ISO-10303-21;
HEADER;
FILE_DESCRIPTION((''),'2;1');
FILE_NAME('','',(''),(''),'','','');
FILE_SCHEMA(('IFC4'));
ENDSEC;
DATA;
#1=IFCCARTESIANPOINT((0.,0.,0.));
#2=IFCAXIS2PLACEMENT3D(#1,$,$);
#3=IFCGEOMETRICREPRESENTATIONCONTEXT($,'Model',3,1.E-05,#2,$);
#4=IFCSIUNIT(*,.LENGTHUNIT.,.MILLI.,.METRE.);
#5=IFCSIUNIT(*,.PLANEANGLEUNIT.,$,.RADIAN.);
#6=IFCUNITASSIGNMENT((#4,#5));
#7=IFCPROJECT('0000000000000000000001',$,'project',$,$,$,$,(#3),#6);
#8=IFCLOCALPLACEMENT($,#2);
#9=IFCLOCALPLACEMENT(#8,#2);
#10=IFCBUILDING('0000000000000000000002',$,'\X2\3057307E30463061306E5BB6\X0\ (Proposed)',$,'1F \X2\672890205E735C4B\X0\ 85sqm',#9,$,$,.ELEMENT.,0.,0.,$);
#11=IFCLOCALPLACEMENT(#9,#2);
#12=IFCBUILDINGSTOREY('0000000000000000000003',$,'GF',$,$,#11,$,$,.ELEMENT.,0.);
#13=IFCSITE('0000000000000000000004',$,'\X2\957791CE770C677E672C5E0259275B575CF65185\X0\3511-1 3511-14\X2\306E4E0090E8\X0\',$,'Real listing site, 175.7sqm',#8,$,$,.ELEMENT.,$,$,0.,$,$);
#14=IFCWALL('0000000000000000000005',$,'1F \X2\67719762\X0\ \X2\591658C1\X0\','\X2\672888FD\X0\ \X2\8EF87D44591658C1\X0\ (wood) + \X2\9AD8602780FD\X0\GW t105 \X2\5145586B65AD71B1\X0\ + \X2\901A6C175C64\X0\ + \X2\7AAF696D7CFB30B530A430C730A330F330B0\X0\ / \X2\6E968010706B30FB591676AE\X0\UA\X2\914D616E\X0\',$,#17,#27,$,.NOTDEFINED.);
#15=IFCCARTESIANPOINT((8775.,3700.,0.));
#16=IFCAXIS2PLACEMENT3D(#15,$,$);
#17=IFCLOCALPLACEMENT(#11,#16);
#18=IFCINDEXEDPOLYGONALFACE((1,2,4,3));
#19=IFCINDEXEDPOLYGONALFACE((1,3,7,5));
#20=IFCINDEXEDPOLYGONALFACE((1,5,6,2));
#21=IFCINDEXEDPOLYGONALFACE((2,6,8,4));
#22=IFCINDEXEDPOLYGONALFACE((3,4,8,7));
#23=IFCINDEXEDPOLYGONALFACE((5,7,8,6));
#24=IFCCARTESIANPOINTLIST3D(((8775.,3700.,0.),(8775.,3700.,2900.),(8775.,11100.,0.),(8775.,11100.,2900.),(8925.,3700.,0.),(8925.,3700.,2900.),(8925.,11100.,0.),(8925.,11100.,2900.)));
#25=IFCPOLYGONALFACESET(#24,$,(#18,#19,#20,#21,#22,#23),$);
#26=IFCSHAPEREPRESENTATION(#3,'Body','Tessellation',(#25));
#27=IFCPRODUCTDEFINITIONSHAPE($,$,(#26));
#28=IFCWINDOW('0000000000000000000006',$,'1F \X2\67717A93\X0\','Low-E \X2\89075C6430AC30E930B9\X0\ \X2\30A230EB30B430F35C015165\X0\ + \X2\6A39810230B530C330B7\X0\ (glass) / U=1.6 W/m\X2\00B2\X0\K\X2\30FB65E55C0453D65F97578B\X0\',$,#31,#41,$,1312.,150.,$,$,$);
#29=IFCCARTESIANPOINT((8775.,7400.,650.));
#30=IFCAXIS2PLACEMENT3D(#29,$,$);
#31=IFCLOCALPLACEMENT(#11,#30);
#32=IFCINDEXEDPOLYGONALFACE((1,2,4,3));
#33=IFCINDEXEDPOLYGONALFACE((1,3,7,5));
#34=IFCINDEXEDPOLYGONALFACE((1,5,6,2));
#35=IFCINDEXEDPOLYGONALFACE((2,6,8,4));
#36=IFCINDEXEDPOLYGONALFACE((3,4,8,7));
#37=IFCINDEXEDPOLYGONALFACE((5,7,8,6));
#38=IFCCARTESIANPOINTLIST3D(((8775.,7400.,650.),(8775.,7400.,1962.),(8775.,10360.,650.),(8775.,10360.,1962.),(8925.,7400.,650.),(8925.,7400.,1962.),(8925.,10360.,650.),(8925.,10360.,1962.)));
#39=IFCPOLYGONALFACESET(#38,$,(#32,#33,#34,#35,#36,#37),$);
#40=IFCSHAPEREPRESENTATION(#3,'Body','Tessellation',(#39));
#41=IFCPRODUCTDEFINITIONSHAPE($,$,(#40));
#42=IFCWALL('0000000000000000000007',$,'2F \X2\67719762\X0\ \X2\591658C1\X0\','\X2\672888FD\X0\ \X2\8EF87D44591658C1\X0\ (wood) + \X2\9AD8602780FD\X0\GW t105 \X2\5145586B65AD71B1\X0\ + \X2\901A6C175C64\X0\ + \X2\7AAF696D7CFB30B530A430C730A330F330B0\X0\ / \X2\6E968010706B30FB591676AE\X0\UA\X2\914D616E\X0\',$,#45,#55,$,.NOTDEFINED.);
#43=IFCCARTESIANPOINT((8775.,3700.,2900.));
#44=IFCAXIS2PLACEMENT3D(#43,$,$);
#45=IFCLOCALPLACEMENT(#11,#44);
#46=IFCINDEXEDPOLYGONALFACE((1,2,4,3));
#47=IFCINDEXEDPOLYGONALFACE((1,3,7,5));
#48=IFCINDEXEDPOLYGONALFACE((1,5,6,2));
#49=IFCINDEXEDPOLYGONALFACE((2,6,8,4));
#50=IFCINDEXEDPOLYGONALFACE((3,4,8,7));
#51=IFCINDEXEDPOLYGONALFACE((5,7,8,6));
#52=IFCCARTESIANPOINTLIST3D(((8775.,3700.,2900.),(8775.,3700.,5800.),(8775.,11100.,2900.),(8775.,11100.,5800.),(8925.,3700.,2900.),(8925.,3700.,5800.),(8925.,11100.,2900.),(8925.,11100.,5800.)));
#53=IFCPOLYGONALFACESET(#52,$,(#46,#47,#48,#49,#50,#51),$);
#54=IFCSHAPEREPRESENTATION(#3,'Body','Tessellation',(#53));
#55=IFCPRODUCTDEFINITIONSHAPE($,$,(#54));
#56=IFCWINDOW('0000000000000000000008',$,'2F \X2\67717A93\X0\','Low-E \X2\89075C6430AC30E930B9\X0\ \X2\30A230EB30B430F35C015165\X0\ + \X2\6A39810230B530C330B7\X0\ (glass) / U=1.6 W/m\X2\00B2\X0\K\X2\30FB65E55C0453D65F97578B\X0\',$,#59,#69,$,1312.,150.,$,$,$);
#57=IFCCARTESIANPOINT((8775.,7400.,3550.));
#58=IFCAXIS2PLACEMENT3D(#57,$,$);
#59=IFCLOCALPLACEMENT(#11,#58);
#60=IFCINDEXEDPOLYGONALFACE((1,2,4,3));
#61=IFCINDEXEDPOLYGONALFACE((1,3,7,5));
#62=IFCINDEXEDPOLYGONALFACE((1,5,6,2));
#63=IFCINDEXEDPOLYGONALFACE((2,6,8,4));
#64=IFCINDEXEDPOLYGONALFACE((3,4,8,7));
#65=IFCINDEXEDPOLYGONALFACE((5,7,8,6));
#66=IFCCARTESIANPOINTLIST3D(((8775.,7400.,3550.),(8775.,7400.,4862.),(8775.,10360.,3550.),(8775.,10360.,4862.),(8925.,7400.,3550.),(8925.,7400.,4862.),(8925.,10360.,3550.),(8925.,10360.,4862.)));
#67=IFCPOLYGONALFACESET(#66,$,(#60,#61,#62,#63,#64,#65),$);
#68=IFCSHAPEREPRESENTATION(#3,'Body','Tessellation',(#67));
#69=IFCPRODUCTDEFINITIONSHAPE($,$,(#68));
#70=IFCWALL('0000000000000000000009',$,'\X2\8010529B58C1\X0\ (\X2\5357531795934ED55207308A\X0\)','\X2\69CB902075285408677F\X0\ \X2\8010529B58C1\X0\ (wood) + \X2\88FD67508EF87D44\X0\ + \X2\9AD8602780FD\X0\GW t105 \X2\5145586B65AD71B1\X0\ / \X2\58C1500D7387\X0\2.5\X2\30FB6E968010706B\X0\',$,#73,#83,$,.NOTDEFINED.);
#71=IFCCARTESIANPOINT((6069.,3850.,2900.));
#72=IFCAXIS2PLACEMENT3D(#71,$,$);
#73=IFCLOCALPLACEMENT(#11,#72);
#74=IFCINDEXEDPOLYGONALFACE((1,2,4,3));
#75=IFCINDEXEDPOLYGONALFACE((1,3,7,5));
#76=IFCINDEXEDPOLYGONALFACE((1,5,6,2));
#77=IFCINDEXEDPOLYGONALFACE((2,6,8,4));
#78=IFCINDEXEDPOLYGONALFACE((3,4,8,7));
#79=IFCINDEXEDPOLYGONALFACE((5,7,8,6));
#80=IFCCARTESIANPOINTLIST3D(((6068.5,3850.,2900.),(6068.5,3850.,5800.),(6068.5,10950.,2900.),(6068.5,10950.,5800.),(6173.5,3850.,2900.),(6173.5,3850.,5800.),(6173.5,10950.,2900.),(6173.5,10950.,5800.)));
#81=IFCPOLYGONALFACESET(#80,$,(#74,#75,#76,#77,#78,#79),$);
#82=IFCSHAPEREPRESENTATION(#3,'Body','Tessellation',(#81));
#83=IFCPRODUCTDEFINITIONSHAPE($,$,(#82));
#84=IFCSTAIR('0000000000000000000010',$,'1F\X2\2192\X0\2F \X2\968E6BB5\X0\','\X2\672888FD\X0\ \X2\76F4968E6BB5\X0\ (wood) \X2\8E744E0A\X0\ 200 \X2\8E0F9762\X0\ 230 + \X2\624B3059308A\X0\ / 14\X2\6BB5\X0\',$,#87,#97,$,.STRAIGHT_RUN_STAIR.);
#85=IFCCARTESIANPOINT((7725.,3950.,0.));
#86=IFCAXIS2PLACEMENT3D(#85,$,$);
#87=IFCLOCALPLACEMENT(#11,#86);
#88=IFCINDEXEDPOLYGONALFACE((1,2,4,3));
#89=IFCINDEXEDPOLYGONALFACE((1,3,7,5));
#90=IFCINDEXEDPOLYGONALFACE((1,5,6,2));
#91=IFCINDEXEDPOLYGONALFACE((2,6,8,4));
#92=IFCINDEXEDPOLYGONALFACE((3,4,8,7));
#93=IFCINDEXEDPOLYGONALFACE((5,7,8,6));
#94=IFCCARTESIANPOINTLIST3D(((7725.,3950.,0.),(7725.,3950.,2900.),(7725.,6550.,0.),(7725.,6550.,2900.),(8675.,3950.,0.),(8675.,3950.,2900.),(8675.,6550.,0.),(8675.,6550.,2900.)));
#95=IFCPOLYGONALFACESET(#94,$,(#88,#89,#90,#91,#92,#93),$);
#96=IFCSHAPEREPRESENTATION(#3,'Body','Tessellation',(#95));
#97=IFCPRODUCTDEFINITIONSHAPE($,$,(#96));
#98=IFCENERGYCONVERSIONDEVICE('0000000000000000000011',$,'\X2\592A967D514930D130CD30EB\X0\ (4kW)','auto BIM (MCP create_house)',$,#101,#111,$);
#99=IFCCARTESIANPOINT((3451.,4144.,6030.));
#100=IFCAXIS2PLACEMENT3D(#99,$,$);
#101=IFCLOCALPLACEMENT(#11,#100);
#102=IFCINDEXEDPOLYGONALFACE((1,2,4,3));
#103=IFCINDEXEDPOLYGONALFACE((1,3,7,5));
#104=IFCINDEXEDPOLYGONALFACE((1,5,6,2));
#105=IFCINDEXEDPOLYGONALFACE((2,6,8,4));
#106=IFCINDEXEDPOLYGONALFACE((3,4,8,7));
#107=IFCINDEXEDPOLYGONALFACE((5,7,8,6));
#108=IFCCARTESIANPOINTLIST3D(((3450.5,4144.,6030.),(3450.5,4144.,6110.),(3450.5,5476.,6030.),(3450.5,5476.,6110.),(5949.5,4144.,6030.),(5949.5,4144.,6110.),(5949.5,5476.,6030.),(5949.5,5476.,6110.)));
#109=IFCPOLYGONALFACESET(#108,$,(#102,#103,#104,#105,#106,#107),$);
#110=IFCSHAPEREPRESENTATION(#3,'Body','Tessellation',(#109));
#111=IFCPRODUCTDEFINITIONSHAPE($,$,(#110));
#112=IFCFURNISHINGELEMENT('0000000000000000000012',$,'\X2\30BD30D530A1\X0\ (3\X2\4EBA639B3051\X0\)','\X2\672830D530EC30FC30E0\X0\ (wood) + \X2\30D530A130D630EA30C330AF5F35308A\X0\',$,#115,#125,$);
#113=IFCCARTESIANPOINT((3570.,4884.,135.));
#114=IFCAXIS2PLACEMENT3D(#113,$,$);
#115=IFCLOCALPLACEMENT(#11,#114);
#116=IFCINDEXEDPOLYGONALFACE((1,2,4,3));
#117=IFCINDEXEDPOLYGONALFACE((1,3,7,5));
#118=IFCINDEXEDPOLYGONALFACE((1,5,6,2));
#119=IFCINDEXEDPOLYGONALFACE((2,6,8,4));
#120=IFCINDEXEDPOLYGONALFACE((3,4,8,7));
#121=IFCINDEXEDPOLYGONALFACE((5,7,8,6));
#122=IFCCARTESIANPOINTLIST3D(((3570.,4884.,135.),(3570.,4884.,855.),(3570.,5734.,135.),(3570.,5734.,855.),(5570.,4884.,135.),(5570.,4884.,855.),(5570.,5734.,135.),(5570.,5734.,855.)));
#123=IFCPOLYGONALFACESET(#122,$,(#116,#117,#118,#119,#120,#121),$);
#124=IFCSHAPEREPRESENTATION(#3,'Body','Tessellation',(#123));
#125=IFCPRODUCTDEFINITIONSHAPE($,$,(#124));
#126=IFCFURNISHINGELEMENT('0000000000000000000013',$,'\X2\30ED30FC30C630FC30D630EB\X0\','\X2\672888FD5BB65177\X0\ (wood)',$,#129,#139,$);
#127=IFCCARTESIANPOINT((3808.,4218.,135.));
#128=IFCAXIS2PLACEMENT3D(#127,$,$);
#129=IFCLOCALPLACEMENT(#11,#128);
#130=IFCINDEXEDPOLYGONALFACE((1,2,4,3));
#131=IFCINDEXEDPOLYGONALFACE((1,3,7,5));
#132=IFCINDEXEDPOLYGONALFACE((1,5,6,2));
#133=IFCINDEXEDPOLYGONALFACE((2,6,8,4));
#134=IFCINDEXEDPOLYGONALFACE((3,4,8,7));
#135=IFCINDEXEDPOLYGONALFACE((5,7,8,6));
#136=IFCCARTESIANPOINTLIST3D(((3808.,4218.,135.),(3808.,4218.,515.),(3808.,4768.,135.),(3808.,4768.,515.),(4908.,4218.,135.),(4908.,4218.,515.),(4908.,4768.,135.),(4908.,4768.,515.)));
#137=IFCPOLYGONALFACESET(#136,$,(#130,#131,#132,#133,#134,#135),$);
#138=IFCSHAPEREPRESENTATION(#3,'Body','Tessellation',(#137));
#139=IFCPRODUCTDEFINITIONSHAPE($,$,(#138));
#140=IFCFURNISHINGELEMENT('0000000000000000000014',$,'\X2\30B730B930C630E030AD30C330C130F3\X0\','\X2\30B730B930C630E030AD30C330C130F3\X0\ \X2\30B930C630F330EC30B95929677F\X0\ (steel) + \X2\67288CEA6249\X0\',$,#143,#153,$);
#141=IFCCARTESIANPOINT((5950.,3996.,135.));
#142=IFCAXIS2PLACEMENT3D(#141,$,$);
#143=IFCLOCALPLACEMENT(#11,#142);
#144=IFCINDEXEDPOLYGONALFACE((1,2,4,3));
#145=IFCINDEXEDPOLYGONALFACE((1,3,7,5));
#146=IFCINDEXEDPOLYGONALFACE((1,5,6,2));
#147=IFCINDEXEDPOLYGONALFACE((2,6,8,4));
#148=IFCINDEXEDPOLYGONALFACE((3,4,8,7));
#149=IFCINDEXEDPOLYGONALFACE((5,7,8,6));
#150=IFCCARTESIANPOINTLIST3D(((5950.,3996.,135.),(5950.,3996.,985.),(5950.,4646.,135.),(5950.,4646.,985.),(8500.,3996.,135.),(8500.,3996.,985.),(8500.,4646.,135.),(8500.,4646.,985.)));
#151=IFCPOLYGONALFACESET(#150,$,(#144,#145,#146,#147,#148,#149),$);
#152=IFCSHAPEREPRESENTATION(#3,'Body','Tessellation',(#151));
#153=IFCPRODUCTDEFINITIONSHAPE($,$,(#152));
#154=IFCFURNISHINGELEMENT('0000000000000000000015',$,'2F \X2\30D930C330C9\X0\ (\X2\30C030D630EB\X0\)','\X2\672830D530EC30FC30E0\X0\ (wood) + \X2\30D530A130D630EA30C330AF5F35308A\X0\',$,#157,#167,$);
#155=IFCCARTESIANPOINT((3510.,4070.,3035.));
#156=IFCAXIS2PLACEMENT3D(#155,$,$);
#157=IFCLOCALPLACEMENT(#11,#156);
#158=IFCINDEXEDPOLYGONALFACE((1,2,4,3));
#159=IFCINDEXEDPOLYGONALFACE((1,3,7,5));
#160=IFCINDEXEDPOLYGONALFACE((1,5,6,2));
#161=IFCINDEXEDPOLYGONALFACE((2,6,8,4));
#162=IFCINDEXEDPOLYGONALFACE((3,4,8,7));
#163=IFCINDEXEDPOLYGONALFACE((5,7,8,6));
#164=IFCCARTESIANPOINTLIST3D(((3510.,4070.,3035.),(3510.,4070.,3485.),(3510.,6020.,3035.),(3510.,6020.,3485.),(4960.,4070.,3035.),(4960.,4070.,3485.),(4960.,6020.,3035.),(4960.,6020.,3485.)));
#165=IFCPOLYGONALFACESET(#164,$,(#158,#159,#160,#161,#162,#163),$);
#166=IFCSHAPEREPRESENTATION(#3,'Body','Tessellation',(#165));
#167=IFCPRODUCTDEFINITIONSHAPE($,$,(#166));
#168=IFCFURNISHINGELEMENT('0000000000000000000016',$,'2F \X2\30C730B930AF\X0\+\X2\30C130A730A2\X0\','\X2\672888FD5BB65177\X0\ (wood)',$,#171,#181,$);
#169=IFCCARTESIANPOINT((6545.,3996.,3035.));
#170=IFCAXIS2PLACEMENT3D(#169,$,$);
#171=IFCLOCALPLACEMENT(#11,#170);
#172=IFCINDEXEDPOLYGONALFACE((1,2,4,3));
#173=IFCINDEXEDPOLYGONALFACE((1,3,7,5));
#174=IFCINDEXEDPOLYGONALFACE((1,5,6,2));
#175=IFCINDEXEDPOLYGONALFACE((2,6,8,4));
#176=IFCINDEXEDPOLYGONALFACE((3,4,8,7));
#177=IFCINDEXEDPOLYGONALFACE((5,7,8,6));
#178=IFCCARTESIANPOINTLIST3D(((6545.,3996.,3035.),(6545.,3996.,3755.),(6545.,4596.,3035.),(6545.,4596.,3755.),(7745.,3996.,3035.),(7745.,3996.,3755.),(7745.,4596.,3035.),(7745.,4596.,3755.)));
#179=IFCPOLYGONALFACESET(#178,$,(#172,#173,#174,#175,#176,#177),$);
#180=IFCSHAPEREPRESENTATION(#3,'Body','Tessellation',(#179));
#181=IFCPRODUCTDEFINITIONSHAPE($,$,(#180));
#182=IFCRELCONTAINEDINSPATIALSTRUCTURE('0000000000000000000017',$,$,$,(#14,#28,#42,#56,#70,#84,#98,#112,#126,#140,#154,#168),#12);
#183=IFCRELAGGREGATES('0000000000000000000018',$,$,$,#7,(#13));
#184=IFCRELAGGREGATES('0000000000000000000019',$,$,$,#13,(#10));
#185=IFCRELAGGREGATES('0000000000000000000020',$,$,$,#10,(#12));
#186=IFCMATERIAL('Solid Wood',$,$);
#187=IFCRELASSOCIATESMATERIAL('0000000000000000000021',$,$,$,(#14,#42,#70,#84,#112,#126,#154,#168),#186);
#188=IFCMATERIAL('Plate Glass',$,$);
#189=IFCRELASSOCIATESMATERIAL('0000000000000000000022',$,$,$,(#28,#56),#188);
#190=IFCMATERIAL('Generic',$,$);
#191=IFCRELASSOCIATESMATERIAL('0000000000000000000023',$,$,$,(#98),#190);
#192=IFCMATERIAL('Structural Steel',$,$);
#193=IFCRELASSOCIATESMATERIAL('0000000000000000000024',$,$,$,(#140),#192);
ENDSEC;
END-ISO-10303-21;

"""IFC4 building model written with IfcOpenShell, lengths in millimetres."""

from ifc_helpers import new_model, si_unit, frame, frame_2d, origin, place, context, project, spatial, rectangle, extrude, material, element, fill, save


model = new_model("IFC4")

# Units and contexts
model_context = context("Model", 3, precision=1e-05, world=origin())
ifc_project = project(units=[si_unit("LENGTHUNIT", "METRE", prefix="MILLI"), si_unit("PLANEANGLEUNIT", "RADIAN")], contexts=[model_context])

# Site, building, storey
site_placement = place(None, origin())
site = spatial("IfcSite", under=ifc_project, at=site_placement, Name="長野県松本市大字島内3511-1 3511-14の一部", ObjectType="Real listing site, 175.7sqm", CompositionType="ELEMENT", RefElevation=0.0)
building_placement = place(site_placement, origin())
building = spatial("IfcBuilding", under=site, at=building_placement, Name="しまうちの家 (Proposed)", ObjectType="1F 木造平屋 85sqm", CompositionType="ELEMENT", ElevationOfRefHeight=0.0, ElevationOfTerrain=0.0)
storey_placement = place(building_placement, origin())
storey = spatial("IfcBuildingStorey", under=building, at=storey_placement, Name="GF", CompositionType="ELEMENT", Elevation=0.0)

# Wall, opening, window
ifc_material_1 = material(Name="Solid Wood")
wall_1_placement = place(storey_placement, frame((8775.0, 3700.0, 0.0)))
wall_1 = element("IfcWall", 1, at=wall_1_placement, inside=storey, material=ifc_material_1, Name="1F 東面 外壁", Description="木製 軸組外壁 (wood) + 高性能GW t105 充填断熱 + 通気層 + 窯業系サイディング / 準耐火・外皮UA配慮", PredefinedType="NOTDEFINED", context=model_context, shape_type="SweptSolid", body=[
    extrude(rectangle(XDim=150.0, YDim=7400.0, at=frame_2d((75.0, 3700.0))), frame((8775.0, 3700.0, 0.0)), (0.0, 0.0, 1.0), 2900.0),
])
opening_1_placement = place(storey_placement, frame((8775.0, 7400.0, 650.0)))
opening_1 = element("IfcOpeningElement", 2, at=opening_1_placement, cuts=wall_1, PredefinedType="NOTDEFINED", context=model_context, shape_type="SweptSolid", body=[
    extrude(rectangle(XDim=150.0, YDim=2960.0, at=frame_2d((75.0, 1480.0))), frame((8775.0, 7400.0, 650.0)), (0.0, 0.0, 1.0), 1312.0),
])
ifc_material_2 = material(Name="Plate Glass")
window_1_placement = place(storey_placement, frame((8775.0, 7400.0, 650.0)))
window_1 = element("IfcWindow", 3, at=window_1_placement, inside=storey, material=ifc_material_2, Name="1F 東窓", Description="Low-E 複層ガラス アルゴン封入 + 樹脂サッシ (glass) / U=1.6 W/m²K・日射取得型", OverallHeight=1312.0, OverallWidth=150.0, context=model_context, shape_type="SweptSolid", body=[
    extrude(rectangle(XDim=150.0, YDim=2960.0, at=frame_2d((75.0, 1480.0))), frame((8775.0, 7400.0, 650.0)), (0.0, 0.0, 1.0), 1312.0),
])
fill(opening_1, window_1)

# Wall, opening, window
wall_2_placement = place(storey_placement, frame((8775.0, 3700.0, 2900.0)))
wall_2 = element("IfcWall", 4, at=wall_2_placement, inside=storey, material=ifc_material_1, Name="2F 東面 外壁", Description="木製 軸組外壁 (wood) + 高性能GW t105 充填断熱 + 通気層 + 窯業系サイディング / 準耐火・外皮UA配慮", PredefinedType="NOTDEFINED", context=model_context, shape_type="SweptSolid", body=[
    extrude(rectangle(XDim=150.0, YDim=7400.0, at=frame_2d((75.0, 3700.0))), frame((8775.0, 3700.0, 2900.0)), (0.0, 0.0, 1.0), 2900.0),
])
opening_2_placement = place(storey_placement, frame((8775.0, 7400.0, 3550.0)))
opening_2 = element("IfcOpeningElement", 5, at=opening_2_placement, cuts=wall_2, PredefinedType="NOTDEFINED", context=model_context, shape_type="SweptSolid", body=[
    extrude(rectangle(XDim=150.0, YDim=2960.0, at=frame_2d((75.0, 1480.0))), frame((8775.0, 7400.0, 3550.0)), (0.0, 0.0, 1.0), 1312.0),
])
window_2_placement = place(storey_placement, frame((8775.0, 7400.0, 3550.0)))
window_2 = element("IfcWindow", 6, at=window_2_placement, inside=storey, material=ifc_material_2, Name="2F 東窓", Description="Low-E 複層ガラス アルゴン封入 + 樹脂サッシ (glass) / U=1.6 W/m²K・日射取得型", OverallHeight=1312.0, OverallWidth=150.0, context=model_context, shape_type="SweptSolid", body=[
    extrude(rectangle(XDim=150.0, YDim=2960.0, at=frame_2d((75.0, 1480.0))), frame((8775.0, 7400.0, 3550.0)), (0.0, 0.0, 1.0), 1312.0),
])
fill(opening_2, window_2)

# Wall
wall_3_placement = place(storey_placement, frame((6069.0, 3850.0, 2900.0)))
element("IfcWall", 7, at=wall_3_placement, inside=storey, material=ifc_material_1, Name="耐力壁 (南北間仕切り)", Description="構造用合板 耐力壁 (wood) + 製材軸組 + 高性能GW t105 充填断熱 / 壁倍率2.5・準耐火", PredefinedType="NOTDEFINED", context=model_context, shape_type="SweptSolid", body=[
    extrude(rectangle(XDim=105.0, YDim=7100.0, at=frame_2d((52.0, 3550.0))), frame((6069.0, 3850.0, 2900.0)), (0.0, 0.0, 1.0), 2900.0),
])

# Stair
stair_placement = place(storey_placement, frame((7725.0, 3950.0, 0.0)))
element("IfcStair", 8, at=stair_placement, inside=storey, material=ifc_material_1, Name="1F→2F 階段", Description="木製 直階段 (wood) 蹴上 200 踏面 230 + 手すり / 14段", PredefinedType="STRAIGHT_RUN_STAIR", context=model_context, shape_type="SweptSolid", body=[
    extrude(rectangle(XDim=950.0, YDim=2600.0, at=frame_2d((475.0, 1300.0))), frame((7725.0, 3950.0, 0.0)), (0.0, 0.0, 1.0), 2900.0),
])

# Energy conversion device
ifc_material_3 = material(Name="Generic")
energy_conversion_device_placement = place(storey_placement, frame((3451.0, 4144.0, 6030.0)))
element("IfcEnergyConversionDevice", 9, at=energy_conversion_device_placement, inside=storey, material=ifc_material_3, Name="太陽光パネル (4kW)", Description="auto BIM (MCP create_house)", context=model_context, shape_type="SweptSolid", body=[
    extrude(rectangle(XDim=2499.0, YDim=1332.0, at=frame_2d((1249.0, 666.0))), frame((3451.0, 4144.0, 6030.0)), (0.0, 0.0, 1.0), 80.0),
])

# Furnishing elements
furnishing_1_placement = place(storey_placement, frame((3570.0, 4884.0, 135.0)))
element("IfcFurnishingElement", 10, at=furnishing_1_placement, inside=storey, material=ifc_material_1, Name="ソファ (3人掛け)", Description="木フレーム (wood) + ファブリック張り", context=model_context, shape_type="SweptSolid", body=[
    extrude(rectangle(XDim=2000.0, YDim=850.0, at=frame_2d((1000.0, 425.0))), frame((3570.0, 4884.0, 135.0)), (0.0, 0.0, 1.0), 720.0),
])
furnishing_2_placement = place(storey_placement, frame((3808.0, 4218.0, 135.0)))
element("IfcFurnishingElement", 11, at=furnishing_2_placement, inside=storey, material=ifc_material_1, Name="ローテーブル", Description="木製家具 (wood)", context=model_context, shape_type="SweptSolid", body=[
    extrude(rectangle(XDim=1100.0, YDim=550.0, at=frame_2d((550.0, 275.0))), frame((3808.0, 4218.0, 135.0)), (0.0, 0.0, 1.0), 380.0),
])
ifc_material_4 = material(Name="Structural Steel")
furnishing_3_placement = place(storey_placement, frame((5950.0, 3996.0, 135.0)))
element("IfcFurnishingElement", 12, at=furnishing_3_placement, inside=storey, material=ifc_material_4, Name="システムキッチン", Description="システムキッチン ステンレス天板 (steel) + 木質扉", context=model_context, shape_type="SweptSolid", body=[
    extrude(rectangle(XDim=2550.0, YDim=650.0, at=frame_2d((1275.0, 325.0))), frame((5950.0, 3996.0, 135.0)), (0.0, 0.0, 1.0), 850.0),
])
furnishing_4_placement = place(storey_placement, frame((3510.0, 4070.0, 3035.0)))
element("IfcFurnishingElement", 13, at=furnishing_4_placement, inside=storey, material=ifc_material_1, Name="2F ベッド (ダブル)", Description="木フレーム (wood) + ファブリック張り", context=model_context, shape_type="SweptSolid", body=[
    extrude(rectangle(XDim=1450.0, YDim=1950.0, at=frame_2d((725.0, 975.0))), frame((3510.0, 4070.0, 3035.0)), (0.0, 0.0, 1.0), 450.0),
])
furnishing_5_placement = place(storey_placement, frame((6545.0, 3996.0, 3035.0)))
element("IfcFurnishingElement", 14, at=furnishing_5_placement, inside=storey, material=ifc_material_1, Name="2F デスク+チェア", Description="木製家具 (wood)", context=model_context, shape_type="SweptSolid", body=[
    extrude(rectangle(XDim=1200.0, YDim=600.0, at=frame_2d((600.0, 300.0))), frame((6545.0, 3996.0, 3035.0)), (0.0, 0.0, 1.0), 720.0),
])

save(model, "model.ifc")
